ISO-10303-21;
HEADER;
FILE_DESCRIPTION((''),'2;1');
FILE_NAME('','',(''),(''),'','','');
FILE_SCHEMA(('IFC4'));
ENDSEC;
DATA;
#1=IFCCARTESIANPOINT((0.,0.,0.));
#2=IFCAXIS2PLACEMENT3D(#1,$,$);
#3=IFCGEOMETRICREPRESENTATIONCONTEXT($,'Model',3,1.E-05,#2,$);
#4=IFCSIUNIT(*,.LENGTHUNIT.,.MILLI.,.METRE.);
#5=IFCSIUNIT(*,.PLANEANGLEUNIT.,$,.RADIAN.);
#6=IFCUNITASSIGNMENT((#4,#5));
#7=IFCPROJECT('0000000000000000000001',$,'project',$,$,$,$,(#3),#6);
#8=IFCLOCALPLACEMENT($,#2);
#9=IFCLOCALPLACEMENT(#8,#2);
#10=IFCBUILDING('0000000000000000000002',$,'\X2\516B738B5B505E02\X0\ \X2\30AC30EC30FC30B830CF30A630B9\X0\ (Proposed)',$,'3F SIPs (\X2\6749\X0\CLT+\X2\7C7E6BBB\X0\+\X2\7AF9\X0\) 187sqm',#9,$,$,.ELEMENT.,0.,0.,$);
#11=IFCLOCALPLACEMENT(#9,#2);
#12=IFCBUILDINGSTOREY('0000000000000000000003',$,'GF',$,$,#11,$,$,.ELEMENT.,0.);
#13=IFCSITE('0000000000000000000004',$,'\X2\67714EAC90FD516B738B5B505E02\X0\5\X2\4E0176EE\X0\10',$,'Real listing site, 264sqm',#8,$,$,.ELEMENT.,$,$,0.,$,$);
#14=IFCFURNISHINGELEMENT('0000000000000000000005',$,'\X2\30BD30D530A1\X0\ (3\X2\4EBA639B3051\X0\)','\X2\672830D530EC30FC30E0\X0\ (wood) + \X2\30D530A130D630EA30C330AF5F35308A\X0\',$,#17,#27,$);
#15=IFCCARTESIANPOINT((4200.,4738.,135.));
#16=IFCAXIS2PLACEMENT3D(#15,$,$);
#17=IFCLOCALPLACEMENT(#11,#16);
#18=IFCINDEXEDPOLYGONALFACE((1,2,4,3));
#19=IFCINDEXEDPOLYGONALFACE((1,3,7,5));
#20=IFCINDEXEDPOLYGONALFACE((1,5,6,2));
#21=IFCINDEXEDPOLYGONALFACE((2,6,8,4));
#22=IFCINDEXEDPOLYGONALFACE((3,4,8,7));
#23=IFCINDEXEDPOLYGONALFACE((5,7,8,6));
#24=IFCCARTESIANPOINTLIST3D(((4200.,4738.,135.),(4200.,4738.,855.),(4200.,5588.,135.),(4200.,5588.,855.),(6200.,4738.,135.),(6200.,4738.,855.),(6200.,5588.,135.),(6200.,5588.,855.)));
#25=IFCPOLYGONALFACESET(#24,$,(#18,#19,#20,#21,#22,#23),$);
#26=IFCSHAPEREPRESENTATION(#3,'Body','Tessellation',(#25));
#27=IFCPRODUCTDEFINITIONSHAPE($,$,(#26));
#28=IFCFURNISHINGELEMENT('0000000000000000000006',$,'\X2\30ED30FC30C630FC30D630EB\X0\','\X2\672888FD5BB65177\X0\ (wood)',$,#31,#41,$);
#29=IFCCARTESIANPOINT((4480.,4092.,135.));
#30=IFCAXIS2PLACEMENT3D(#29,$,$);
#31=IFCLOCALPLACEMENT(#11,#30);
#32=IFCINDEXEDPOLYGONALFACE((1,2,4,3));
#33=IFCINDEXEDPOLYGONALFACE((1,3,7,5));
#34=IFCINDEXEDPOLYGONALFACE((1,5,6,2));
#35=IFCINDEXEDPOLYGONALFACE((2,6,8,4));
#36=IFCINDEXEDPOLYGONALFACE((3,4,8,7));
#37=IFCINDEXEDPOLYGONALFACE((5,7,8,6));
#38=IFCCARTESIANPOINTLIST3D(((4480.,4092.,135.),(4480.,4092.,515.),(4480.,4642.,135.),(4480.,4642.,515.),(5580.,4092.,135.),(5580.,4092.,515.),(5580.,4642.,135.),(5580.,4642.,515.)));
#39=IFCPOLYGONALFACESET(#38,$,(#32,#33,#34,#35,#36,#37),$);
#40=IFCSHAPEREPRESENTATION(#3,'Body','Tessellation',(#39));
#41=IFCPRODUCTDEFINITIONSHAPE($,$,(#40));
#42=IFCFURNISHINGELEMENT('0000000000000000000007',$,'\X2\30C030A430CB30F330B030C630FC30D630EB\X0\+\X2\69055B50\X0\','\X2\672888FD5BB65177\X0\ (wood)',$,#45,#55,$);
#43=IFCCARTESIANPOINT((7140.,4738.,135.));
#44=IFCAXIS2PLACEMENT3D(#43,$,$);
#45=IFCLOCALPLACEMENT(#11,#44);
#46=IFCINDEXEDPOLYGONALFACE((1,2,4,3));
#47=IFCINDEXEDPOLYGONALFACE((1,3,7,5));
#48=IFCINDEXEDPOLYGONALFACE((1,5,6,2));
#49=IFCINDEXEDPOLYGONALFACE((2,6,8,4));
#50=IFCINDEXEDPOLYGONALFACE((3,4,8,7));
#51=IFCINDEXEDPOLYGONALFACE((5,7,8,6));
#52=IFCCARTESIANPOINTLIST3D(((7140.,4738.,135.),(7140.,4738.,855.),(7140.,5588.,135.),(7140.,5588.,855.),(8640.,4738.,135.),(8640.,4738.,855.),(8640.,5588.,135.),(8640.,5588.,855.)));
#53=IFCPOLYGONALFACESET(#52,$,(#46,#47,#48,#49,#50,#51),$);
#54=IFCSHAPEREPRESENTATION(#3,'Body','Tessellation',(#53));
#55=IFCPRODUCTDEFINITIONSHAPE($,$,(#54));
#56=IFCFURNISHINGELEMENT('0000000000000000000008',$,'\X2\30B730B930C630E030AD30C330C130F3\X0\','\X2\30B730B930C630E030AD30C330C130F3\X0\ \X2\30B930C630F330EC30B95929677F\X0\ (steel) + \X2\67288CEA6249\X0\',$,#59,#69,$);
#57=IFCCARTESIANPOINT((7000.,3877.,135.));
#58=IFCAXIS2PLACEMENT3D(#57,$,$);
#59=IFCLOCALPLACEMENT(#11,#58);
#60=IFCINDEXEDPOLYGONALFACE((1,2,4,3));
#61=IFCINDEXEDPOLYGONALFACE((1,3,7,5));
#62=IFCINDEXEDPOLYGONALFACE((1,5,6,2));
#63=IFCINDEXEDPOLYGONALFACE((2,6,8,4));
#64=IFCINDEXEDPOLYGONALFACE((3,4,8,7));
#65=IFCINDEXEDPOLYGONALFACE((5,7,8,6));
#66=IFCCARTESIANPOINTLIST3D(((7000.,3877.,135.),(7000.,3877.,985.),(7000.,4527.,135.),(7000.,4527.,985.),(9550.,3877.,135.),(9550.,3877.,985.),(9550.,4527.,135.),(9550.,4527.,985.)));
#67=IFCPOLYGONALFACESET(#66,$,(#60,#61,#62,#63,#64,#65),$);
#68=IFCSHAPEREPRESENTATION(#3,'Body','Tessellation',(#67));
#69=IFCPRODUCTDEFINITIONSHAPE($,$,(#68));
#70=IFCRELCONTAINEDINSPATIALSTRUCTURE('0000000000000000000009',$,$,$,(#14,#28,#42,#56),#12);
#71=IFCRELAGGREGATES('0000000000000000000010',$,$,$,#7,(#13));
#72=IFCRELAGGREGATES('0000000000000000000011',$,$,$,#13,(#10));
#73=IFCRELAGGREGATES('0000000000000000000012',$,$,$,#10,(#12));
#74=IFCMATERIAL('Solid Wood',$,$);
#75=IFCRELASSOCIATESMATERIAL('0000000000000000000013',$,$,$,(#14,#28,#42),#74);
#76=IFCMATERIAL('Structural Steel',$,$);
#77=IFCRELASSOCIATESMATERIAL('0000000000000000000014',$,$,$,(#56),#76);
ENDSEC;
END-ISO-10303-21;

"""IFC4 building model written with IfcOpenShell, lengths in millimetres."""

from ifc_helpers import new_model, si_unit, frame, frame_2d, origin, place, context, project, spatial, rectangle, extrude, material, element, save


model = new_model("IFC4")

# Units and contexts
model_context = context("Model", 3, precision=1e-05, world=origin())
ifc_project = project(units=[si_unit("LENGTHUNIT", "METRE", prefix="MILLI"), si_unit("PLANEANGLEUNIT", "RADIAN")], contexts=[model_context])

# Site, building, storey
site_placement = place(None, origin())
site = spatial("IfcSite", under=ifc_project, at=site_placement, Name="東京都八王子市5丁目10", ObjectType="Real listing site, 264sqm", CompositionType="ELEMENT", RefElevation=0.0)
building_placement = place(site_placement, origin())
building = spatial("IfcBuilding", under=site, at=building_placement, Name="八王子市 ガレージハウス (Proposed)", ObjectType="3F SIPs (杉CLT+籾殻+竹) 187sqm", CompositionType="ELEMENT", ElevationOfRefHeight=0.0, ElevationOfTerrain=0.0)
storey_placement = place(building_placement, origin())
storey = spatial("IfcBuildingStorey", under=building, at=storey_placement, Name="GF", CompositionType="ELEMENT", Elevation=0.0)

# Shared definitions
ifc_material_1 = material(Name="Solid Wood")

# Furnishing elements
furnishing_1_placement = place(storey_placement, frame((4200.0, 4738.0, 135.0)))
element("IfcFurnishingElement", 1, at=furnishing_1_placement, inside=storey, material=ifc_material_1, Name="ソファ (3人掛け)", Description="木フレーム (wood) + ファブリック張り", context=model_context, shape_type="SweptSolid", body=[
    extrude(rectangle(XDim=2000.0, YDim=850.0, at=frame_2d((1000.0, 425.0))), frame((4200.0, 4738.0, 135.0)), (0.0, 0.0, 1.0), 720.0),
])
furnishing_2_placement = place(storey_placement, frame((4480.0, 4092.0, 135.0)))
element("IfcFurnishingElement", 2, at=furnishing_2_placement, inside=storey, material=ifc_material_1, Name="ローテーブル", Description="木製家具 (wood)", context=model_context, shape_type="SweptSolid", body=[
    extrude(rectangle(XDim=1100.0, YDim=550.0, at=frame_2d((550.0, 275.0))), frame((4480.0, 4092.0, 135.0)), (0.0, 0.0, 1.0), 380.0),
])
furnishing_3_placement = place(storey_placement, frame((7140.0, 4738.0, 135.0)))
element("IfcFurnishingElement", 3, at=furnishing_3_placement, inside=storey, material=ifc_material_1, Name="ダイニングテーブル+椅子", Description="木製家具 (wood)", context=model_context, shape_type="SweptSolid", body=[
    extrude(rectangle(XDim=1500.0, YDim=850.0, at=frame_2d((750.0, 425.0))), frame((7140.0, 4738.0, 135.0)), (0.0, 0.0, 1.0), 720.0),
])
ifc_material_2 = material(Name="Structural Steel")
furnishing_4_placement = place(storey_placement, frame((7000.0, 3877.0, 135.0)))
element("IfcFurnishingElement", 4, at=furnishing_4_placement, inside=storey, material=ifc_material_2, Name="システムキッチン", Description="システムキッチン ステンレス天板 (steel) + 木質扉", context=model_context, shape_type="SweptSolid", body=[
    extrude(rectangle(XDim=2550.0, YDim=650.0, at=frame_2d((1275.0, 325.0))), frame((7000.0, 3877.0, 135.0)), (0.0, 0.0, 1.0), 850.0),
])

save(model, "model.ifc")
